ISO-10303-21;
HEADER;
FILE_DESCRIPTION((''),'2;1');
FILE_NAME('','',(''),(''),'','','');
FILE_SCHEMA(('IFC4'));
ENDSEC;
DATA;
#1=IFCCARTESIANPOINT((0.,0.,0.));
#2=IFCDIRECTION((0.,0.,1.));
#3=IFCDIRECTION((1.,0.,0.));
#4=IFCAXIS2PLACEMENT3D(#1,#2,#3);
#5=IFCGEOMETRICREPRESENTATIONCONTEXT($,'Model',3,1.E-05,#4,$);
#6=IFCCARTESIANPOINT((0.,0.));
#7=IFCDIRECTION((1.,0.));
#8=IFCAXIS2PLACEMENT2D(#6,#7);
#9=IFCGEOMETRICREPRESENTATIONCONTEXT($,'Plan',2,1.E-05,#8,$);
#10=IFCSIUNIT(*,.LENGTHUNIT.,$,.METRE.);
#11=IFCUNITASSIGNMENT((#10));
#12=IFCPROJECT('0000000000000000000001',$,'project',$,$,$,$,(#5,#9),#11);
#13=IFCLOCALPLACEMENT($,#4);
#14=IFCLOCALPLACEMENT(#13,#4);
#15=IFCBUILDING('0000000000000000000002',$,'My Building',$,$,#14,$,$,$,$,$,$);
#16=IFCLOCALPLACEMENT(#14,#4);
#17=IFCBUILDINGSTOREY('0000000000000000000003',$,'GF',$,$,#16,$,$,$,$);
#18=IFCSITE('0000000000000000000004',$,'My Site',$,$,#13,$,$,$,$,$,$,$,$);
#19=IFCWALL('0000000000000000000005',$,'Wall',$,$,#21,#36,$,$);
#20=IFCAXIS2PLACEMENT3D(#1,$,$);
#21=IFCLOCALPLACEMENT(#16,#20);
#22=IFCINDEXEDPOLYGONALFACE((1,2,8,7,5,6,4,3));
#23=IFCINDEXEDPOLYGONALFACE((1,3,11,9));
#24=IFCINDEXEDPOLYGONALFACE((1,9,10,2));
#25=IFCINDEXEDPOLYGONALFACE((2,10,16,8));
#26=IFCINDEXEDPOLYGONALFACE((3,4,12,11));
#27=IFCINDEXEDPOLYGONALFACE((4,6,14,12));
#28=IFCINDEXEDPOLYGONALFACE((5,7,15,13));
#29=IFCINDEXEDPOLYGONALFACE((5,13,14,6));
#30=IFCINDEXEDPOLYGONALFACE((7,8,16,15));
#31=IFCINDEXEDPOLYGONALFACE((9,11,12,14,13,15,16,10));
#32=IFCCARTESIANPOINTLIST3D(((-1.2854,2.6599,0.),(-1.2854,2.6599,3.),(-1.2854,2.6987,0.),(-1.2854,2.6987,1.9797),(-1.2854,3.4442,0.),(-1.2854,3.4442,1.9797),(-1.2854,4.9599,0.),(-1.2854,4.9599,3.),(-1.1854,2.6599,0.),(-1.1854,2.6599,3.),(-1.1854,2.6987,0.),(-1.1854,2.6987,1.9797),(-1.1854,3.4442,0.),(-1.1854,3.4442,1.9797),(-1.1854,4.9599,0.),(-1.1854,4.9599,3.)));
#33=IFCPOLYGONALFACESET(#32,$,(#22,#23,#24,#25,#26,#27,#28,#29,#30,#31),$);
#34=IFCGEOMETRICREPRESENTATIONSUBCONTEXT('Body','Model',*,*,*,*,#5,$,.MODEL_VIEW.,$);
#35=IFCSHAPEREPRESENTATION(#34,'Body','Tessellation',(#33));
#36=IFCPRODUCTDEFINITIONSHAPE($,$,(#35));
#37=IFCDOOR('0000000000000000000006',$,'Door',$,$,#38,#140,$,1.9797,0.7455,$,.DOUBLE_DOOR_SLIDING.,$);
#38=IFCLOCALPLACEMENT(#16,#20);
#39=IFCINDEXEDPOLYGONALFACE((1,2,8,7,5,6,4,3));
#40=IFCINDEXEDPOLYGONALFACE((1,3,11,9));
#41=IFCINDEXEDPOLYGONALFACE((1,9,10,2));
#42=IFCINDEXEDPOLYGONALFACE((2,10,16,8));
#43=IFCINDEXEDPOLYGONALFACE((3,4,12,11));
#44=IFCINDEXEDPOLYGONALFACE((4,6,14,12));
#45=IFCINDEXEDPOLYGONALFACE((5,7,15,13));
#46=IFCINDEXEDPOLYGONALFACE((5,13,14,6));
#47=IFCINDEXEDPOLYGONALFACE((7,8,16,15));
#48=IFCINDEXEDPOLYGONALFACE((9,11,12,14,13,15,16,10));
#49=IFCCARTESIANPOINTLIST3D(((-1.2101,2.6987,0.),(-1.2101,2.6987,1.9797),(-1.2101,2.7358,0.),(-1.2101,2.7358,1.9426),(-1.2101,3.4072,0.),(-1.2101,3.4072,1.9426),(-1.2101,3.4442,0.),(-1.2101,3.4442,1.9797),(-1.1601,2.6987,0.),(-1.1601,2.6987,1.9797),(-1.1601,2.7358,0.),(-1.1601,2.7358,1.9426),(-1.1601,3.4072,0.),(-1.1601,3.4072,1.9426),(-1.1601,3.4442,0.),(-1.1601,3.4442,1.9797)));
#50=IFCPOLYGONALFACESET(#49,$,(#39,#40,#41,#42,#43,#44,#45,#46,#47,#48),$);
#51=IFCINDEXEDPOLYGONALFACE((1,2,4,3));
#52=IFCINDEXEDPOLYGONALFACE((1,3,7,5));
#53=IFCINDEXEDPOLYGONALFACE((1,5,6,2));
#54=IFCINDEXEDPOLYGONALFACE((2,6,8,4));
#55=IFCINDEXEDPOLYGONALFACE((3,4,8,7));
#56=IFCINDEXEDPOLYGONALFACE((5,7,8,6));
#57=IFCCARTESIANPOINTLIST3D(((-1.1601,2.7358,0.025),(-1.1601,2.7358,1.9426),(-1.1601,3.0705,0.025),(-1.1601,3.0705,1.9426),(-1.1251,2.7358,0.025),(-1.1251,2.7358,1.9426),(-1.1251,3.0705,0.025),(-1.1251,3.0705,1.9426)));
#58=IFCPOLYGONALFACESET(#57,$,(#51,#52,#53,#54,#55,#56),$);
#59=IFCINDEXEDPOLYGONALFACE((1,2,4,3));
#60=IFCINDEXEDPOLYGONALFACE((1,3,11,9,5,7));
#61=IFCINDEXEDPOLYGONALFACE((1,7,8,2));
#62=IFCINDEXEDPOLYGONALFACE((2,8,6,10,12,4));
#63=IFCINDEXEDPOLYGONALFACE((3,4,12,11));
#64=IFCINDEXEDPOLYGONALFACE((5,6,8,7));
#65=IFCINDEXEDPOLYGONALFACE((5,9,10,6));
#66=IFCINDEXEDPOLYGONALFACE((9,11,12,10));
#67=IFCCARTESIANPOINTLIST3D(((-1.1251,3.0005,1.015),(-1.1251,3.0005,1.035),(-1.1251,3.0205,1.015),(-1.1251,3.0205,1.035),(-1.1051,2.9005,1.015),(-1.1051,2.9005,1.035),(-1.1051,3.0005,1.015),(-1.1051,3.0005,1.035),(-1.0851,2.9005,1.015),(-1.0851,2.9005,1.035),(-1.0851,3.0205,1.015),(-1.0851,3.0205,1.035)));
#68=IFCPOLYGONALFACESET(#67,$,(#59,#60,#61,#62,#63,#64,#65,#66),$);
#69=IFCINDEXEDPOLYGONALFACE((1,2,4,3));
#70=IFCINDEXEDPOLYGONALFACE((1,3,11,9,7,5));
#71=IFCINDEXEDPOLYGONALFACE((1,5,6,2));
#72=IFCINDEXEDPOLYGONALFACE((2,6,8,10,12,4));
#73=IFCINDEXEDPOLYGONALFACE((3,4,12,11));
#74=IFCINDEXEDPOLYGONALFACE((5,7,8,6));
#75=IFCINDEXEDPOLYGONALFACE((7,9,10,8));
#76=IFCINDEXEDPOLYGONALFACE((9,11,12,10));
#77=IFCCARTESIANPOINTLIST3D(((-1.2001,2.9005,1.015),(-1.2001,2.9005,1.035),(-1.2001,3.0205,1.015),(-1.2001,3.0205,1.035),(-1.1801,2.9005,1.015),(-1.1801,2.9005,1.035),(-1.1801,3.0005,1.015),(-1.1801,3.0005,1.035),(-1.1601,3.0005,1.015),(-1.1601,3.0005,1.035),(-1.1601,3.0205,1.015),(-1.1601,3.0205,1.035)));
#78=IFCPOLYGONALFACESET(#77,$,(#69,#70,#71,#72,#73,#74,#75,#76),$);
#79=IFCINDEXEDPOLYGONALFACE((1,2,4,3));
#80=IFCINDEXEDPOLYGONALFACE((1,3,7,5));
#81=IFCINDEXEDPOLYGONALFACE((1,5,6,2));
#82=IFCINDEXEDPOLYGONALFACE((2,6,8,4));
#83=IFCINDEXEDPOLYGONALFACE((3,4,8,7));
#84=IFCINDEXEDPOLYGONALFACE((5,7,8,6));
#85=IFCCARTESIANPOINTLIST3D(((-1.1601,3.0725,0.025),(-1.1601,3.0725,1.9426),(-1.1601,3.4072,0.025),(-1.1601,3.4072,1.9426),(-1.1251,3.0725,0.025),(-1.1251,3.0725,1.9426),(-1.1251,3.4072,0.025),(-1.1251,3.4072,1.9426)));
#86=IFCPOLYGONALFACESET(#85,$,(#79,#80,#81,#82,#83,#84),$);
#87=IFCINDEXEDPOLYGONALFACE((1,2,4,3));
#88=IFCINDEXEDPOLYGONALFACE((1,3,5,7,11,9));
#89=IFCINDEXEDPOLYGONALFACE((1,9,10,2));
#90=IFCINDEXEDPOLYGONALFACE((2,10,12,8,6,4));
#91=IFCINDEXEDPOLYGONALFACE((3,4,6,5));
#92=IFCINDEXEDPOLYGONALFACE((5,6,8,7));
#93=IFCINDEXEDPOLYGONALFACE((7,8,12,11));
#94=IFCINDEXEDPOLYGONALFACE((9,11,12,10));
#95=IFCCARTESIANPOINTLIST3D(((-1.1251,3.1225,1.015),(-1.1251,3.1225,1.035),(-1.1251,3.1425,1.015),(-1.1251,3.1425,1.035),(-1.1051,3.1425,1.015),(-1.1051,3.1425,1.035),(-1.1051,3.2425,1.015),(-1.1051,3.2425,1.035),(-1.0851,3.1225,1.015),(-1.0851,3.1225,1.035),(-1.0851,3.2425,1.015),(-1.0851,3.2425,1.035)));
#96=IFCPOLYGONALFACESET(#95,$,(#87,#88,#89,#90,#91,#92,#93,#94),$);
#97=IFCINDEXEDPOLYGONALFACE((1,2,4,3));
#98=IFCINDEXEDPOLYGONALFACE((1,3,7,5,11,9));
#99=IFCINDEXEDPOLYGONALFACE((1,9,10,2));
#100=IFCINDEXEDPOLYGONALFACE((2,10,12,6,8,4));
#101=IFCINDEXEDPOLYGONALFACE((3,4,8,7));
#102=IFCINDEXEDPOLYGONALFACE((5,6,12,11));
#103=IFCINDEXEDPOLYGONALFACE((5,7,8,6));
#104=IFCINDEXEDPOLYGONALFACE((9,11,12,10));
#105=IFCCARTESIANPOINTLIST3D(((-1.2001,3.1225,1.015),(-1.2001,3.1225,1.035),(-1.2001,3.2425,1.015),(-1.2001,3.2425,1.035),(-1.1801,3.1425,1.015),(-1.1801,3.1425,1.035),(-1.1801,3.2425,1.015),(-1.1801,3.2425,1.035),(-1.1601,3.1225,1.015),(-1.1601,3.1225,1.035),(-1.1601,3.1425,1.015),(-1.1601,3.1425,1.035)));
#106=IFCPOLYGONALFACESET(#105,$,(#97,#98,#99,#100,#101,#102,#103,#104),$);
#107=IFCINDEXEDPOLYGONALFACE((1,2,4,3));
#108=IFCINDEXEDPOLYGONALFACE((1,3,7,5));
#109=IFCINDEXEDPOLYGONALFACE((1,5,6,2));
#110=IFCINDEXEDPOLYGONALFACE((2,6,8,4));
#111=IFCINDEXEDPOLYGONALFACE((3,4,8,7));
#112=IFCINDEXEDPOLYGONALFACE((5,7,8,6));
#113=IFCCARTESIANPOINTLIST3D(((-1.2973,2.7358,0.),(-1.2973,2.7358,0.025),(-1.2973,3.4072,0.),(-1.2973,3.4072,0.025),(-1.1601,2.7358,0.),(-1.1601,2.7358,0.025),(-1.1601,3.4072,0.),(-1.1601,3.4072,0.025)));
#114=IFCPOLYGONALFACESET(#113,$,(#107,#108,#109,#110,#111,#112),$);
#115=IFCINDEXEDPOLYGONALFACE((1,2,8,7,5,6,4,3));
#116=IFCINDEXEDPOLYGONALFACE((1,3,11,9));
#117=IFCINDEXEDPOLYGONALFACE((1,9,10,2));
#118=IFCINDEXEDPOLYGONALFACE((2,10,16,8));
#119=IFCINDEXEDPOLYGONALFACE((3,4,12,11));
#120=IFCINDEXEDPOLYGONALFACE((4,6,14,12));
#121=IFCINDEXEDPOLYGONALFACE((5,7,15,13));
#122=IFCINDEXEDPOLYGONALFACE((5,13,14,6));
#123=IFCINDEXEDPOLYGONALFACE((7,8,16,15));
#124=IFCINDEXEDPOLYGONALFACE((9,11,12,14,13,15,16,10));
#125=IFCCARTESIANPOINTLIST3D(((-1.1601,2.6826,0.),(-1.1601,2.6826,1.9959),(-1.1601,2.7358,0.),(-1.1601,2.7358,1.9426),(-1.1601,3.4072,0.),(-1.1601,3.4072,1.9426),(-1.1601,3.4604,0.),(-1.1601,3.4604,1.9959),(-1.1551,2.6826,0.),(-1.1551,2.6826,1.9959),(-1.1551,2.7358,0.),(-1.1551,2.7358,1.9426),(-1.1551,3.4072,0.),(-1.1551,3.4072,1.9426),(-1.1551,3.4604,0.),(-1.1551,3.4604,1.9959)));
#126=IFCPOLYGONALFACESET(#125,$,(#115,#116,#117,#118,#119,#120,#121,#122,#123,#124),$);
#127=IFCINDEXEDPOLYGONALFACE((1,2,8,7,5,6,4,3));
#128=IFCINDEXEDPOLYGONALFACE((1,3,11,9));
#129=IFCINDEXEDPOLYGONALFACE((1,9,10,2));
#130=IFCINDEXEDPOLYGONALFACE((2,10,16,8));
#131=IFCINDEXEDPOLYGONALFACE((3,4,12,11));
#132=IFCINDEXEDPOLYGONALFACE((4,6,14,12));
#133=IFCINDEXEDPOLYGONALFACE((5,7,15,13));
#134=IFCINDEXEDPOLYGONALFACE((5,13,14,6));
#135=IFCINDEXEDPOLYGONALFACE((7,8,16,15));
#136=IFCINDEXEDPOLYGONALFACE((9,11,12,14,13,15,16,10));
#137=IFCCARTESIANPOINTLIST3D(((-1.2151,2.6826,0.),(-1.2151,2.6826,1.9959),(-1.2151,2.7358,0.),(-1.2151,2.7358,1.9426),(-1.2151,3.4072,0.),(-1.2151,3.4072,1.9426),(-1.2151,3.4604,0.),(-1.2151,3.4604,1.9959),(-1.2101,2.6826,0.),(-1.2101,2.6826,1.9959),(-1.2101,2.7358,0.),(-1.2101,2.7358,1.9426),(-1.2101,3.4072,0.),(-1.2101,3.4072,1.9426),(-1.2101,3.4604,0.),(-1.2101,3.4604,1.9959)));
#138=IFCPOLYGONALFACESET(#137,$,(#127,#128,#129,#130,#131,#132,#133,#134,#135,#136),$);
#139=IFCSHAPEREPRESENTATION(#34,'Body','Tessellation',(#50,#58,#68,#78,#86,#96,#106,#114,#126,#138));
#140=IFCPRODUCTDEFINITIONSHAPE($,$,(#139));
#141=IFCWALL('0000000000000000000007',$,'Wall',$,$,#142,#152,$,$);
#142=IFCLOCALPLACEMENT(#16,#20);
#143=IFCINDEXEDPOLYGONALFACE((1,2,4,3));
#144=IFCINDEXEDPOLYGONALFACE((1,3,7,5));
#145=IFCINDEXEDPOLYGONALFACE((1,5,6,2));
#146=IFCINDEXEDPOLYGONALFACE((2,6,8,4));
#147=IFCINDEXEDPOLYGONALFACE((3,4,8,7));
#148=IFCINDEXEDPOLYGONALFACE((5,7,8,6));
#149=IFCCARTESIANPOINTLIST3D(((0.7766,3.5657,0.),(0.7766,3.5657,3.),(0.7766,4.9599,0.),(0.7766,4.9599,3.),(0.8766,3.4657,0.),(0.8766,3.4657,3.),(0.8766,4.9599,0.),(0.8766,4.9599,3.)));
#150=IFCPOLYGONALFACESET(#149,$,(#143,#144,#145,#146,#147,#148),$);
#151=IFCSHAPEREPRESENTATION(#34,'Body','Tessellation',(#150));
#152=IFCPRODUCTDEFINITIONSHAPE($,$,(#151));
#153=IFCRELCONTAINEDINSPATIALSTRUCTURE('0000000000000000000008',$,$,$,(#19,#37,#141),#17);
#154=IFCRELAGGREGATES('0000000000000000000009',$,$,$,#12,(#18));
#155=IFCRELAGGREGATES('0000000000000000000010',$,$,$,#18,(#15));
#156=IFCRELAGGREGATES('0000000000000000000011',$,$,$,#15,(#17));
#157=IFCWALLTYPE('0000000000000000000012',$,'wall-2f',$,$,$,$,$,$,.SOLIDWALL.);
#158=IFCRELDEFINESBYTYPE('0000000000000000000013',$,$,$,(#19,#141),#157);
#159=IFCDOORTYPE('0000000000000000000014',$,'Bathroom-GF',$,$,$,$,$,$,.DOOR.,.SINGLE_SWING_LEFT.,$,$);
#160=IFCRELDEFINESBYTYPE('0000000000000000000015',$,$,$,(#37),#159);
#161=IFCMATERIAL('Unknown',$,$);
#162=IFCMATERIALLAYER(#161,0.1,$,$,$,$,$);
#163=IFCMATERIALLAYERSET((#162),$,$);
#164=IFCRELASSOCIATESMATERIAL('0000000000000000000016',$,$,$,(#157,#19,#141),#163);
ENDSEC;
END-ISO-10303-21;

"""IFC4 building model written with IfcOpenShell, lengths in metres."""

from ifc_helpers import new_model, entity, si_unit, frame, origin_with_axes, origin_2d_with_axis, place, context, subcontext, project, spatial, line, indexed_curve, outline, extrude, shape, source, transform, mapped, material, layer, layer_set, layer_usage, type_object, type_shapes, element, fill, save


model = new_model("IFC4")

# Units and contexts
model_context = context("Model", 3, precision=1e-05, world=origin_with_axes())
plan_context = context("Plan", 2, precision=1e-05, world=origin_2d_with_axis())
body_context_1 = subcontext(model_context, "Body", "Model", "MODEL_VIEW")
body_context_2 = subcontext(plan_context, "Body", "Plan", "PLAN_VIEW")
ifc_project = project(units=[si_unit("LENGTHUNIT", "METRE")], contexts=[model_context, plan_context])

# Site, building, storey
site_placement = place(None, origin_with_axes())
site = spatial("IfcSite", under=ifc_project, at=site_placement, Name="My Site")
building_placement = place(site_placement, origin_with_axes())
building = spatial("IfcBuilding", under=site, at=building_placement, Name="My Building")
storey_placement = place(building_placement, origin_with_axes())
storey = spatial("IfcBuildingStorey", under=building, at=storey_placement, Name="GF")

# Shared definitions
ifc_material = material(Name="Unknown")

# Shared definitions
ifc_layer_1 = layer(ifc_material, 0.1)
ifc_layer_set_1 = layer_set([ifc_layer_1])
wall_type = type_object("IfcWallType", Name="wall-2f", PredefinedType="SOLIDWALL", material=ifc_layer_set_1)

# Wall, opening, door
ifc_layer_usage_1 = layer_usage(ifc_layer_set_1, "AXIS2", "POSITIVE", 0.0)
wall_1_placement = place(storey_placement, frame((-1.1854, 2.6599, 0.0), z_axis=(0.0, 0.0, 1.0), x_axis=(0.0, 1.0, 0.0)))
wall_1 = element("IfcWall", 1, at=wall_1_placement, inside=storey, type_object=wall_type, material=ifc_layer_usage_1, Name="Wall", context=body_context_1, shape_type="SweptSolid", body=[
    extrude(outline(indexed_curve([(0.0, 0.0), (0.0, 0.1), (2.3, 0.1), (2.3, 0.0)], segments=[line(1, 2, 3, 4, 1)])), origin_with_axes(), (0.0, 0.0, 1.0), 3.0),
])
shared_shape_1 = source(origin_with_axes(), body_context_1, "Body", "SweptSolid", [
    extrude(outline(indexed_curve([(0.0, 0.0), (0.7455, 0.0), (0.7455, 1.9797), (0.0, 1.9797)], segments=[line(1, 2, 3, 4, 1)])), frame((0.0, -0.6, 0.0), z_axis=(0.0, -1.0, 0.0), x_axis=(1.0, 0.0, 0.0)), (0.0, 0.0, -1.0), 1.2),
])
opening_1_placement = place(wall_1_placement, frame((0.0388, -0.0253, 0.0), z_axis=(0.0, 0.0, 1.0), x_axis=(1.0, 0.0, 0.0)))
opening_1 = element("IfcOpeningElement", 2, at=opening_1_placement, cuts=wall_1, PredefinedType="OPENING", context=body_context_1, shape_type="MappedRepresentation", body=[
    mapped(shared_shape_1, transform((0.0, 0.0, 0.0), x_axis=(1.0, 0.0, 0.0), y_axis=(0.0, 1.0, 0.0), z_axis=(0.0, 0.0, 1.0), scale=1.0)),
])
door_type_1 = type_object("IfcDoorType", Name="Bathroom-GF", OperationType="SINGLE_SWING_LEFT", PredefinedType="DOOR")
shared_shape_2 = source(origin_with_axes(), body_context_1, "Body", "SweptSolid", [
    extrude(outline(indexed_curve([(0.0, 0.0), (0.0, 1.9797), (0.7455, 1.9797), (0.7455, 0.0), (0.7084, 0.0), (0.7084, 1.9426), (0.0371, 1.9426), (0.0371, 0.0)], segments=[line(1, 2, 3, 4, 5, 6, 7, 8, 1)])), frame((0.0, 0.0, 0.0), z_axis=(0.0, -1.0, 0.0), x_axis=(1.0, 0.0, 0.0)), (0.0, 0.0, -1.0), 0.05),
    extrude(outline(indexed_curve([(0.0, 0.0), (0.3347, 0.0), (0.3347, 0.035), (0.0, 0.035)], segments=[line(1, 2, 3, 4, 1)])), frame((0.0371, -0.035, 0.025), z_axis=(0.0, 0.0, 1.0), x_axis=(1.0, 0.0, 0.0)), (0.0, 0.0, 1.0), 1.9176),
    extrude(outline(indexed_curve([(0.0, 0.0), (0.0, -0.04), (-0.12, -0.04), (-0.12, -0.02), (-0.02, -0.02), (-0.02, 0.0)], segments=[line(1, 2, 3, 4, 5, 6, 1)])), frame((0.3218, -0.035, 1.015), z_axis=(0.0, 0.0, 1.0), x_axis=(1.0, 0.0, 0.0)), (0.0, 0.0, 1.0), 0.02),
    extrude(outline(indexed_curve([(0.0, 0.0), (0.0, 0.04), (-0.12, 0.04), (-0.12, 0.02), (-0.02, 0.02), (-0.02, 0.0)], segments=[line(1, 2, 3, 4, 5, 6, 1)])), frame((0.3218, 0.0, 1.015), z_axis=(0.0, 0.0, 1.0), x_axis=(1.0, 0.0, 0.0)), (0.0, 0.0, 1.0), 0.02),
    extrude(outline(indexed_curve([(0.0, 0.0), (-0.3347, 0.0), (-0.3347, 0.035), (0.0, 0.035)], segments=[line(1, 2, 3, 4, 1)])), frame((0.7084, -0.035, 0.025), z_axis=(0.0, 0.0, 1.0), x_axis=(1.0, 0.0, 0.0)), (0.0, 0.0, 1.0), 1.9176),
    extrude(outline(indexed_curve([(0.0, 0.0), (0.0, -0.04), (0.12, -0.04), (0.12, -0.02), (0.02, -0.02), (0.02, 0.0)], segments=[line(1, 2, 3, 4, 5, 6, 1)])), frame((0.4238, -0.035, 1.015), z_axis=(0.0, 0.0, 1.0), x_axis=(1.0, 0.0, 0.0)), (0.0, 0.0, 1.0), 0.02),
    extrude(outline(indexed_curve([(0.0, 0.0), (0.0, 0.04), (0.12, 0.04), (0.12, 0.02), (0.02, 0.02), (0.02, 0.0)], segments=[line(1, 2, 3, 4, 5, 6, 1)])), frame((0.4238, 0.0, 1.015), z_axis=(0.0, 0.0, 1.0), x_axis=(1.0, 0.0, 0.0)), (0.0, 0.0, 1.0), 0.02),
    extrude(outline(indexed_curve([(0.0, 0.0), (0.6713, 0.0), (0.6713, 0.1372), (0.0, 0.1372)], segments=[line(1, 2, 3, 4, 1)])), frame((0.0371, 0.0, 0.0), z_axis=(0.0, 0.0, 1.0), x_axis=(1.0, 0.0, 0.0)), (0.0, 0.0, 1.0), 0.025),
    extrude(outline(indexed_curve([(0.0, 0.0), (0.0, 1.9959), (0.7778, 1.9959), (0.7778, 0.0), (0.7246, 0.0), (0.7246, 1.9426), (0.0532, 1.9426), (0.0532, 0.0)], segments=[line(1, 2, 3, 4, 5, 6, 7, 8, 1)])), frame((-0.0162, -0.005, 0.0), z_axis=(0.0, -1.0, 0.0), x_axis=(1.0, 0.0, 0.0)), (0.0, 0.0, -1.0), 0.005),
    extrude(outline(indexed_curve([(0.0, 0.0), (0.0, 1.9959), (0.7778, 1.9959), (0.7778, 0.0), (0.7246, 0.0), (0.7246, 1.9426), (0.0532, 1.9426), (0.0532, 0.0)], segments=[line(1, 2, 3, 4, 5, 6, 7, 8, 1)])), frame((-0.0162, 0.05, 0.0), z_axis=(0.0, -1.0, 0.0), x_axis=(1.0, 0.0, 0.0)), (0.0, 0.0, -1.0), 0.005),
])
shared_shape_3 = source(origin_with_axes(), body_context_2, "Body", "Curve2D", [
    entity("IfcIndexedPolyCurve", entity("IfcCartesianPointList2D", [[0.0, 0.0], [0.0371, 0.0], [0.0371, 0.05], [0.0, 0.05]]), [entity("IfcLineIndex", [1, 2, 3, 4, 1])]),
    entity("IfcIndexedPolyCurve", entity("IfcCartesianPointList2D", [[0.7455, 0.0], [0.7084, 0.0], [0.7084, 0.05], [0.7455, 0.05]]), [entity("IfcLineIndex", [1, 2, 3, 4, 1])]),
    entity("IfcIndexedPolyCurve", entity("IfcCartesianPointList2D", [[-0.1307, -0.035], [0.2049, -0.035], [0.2049, 0.0], [-0.1307, 0.0]]), [entity("IfcLineIndex", [1, 2, 3, 4, 1])]),
    entity("IfcIndexedPolyCurve", entity("IfcCartesianPointList2D", [[0.8763, -0.035], [0.5406, -0.035], [0.5406, 0.0], [0.8763, 0.0]]), [entity("IfcLineIndex", [1, 2, 3, 4, 1])]),
])
type_shapes(door_type_1, [shared_shape_2, shared_shape_3])
door_1_placement = place(opening_1_placement, frame((0.0, 0.0, 0.0), z_axis=(0.0, 0.0, 1.0), x_axis=(1.0, 0.0, 0.0)))
door_1 = element("IfcDoor", 3, at=door_1_placement, inside=storey, type_object=door_type_1, Name="Door", OperationType="DOUBLE_DOOR_SLIDING", OverallHeight=1.9797, OverallWidth=0.7455, shapes=[
    shape(body_context_1, "Body", "MappedRepresentation", [mapped(shared_shape_2, transform((0.0, 0.0, 0.0), x_axis=(1.0, 0.0, 0.0), y_axis=(0.0, 1.0, 0.0), z_axis=(0.0, 0.0, 1.0), scale=1.0))]),
    shape(body_context_2, "Body", "MappedRepresentation", [mapped(shared_shape_3, transform((0.0, 0.0, 0.0), x_axis=(1.0, 0.0, 0.0), y_axis=(0.0, 1.0, 0.0), z_axis=(0.0, 0.0, 1.0), scale=1.0))]),
])
fill(opening_1, door_1)

# Wall
ifc_layer_usage_2 = layer_usage(ifc_layer_set_1, "AXIS2", "POSITIVE", 0.0)
wall_2_placement = place(storey_placement, frame((0.7766, 5.0599, 0.0), z_axis=(0.0, 0.0, 1.0), x_axis=(0.0, -1.0, 0.0)))
element("IfcWall", 4, at=wall_2_placement, inside=storey, type_object=wall_type, material=ifc_layer_usage_2, Name="Wall", context=body_context_1, shape_type="SweptSolid", body=[
    extrude(outline(indexed_curve([(0.1, 0.0), (0.1, 0.1), (1.5942, 0.1), (1.4942, 0.0)], segments=[line(1, 2, 3, 4, 1)])), origin_with_axes(), (0.0, 0.0, 1.0), 3.0),
])

save(model, "model.ifc")
